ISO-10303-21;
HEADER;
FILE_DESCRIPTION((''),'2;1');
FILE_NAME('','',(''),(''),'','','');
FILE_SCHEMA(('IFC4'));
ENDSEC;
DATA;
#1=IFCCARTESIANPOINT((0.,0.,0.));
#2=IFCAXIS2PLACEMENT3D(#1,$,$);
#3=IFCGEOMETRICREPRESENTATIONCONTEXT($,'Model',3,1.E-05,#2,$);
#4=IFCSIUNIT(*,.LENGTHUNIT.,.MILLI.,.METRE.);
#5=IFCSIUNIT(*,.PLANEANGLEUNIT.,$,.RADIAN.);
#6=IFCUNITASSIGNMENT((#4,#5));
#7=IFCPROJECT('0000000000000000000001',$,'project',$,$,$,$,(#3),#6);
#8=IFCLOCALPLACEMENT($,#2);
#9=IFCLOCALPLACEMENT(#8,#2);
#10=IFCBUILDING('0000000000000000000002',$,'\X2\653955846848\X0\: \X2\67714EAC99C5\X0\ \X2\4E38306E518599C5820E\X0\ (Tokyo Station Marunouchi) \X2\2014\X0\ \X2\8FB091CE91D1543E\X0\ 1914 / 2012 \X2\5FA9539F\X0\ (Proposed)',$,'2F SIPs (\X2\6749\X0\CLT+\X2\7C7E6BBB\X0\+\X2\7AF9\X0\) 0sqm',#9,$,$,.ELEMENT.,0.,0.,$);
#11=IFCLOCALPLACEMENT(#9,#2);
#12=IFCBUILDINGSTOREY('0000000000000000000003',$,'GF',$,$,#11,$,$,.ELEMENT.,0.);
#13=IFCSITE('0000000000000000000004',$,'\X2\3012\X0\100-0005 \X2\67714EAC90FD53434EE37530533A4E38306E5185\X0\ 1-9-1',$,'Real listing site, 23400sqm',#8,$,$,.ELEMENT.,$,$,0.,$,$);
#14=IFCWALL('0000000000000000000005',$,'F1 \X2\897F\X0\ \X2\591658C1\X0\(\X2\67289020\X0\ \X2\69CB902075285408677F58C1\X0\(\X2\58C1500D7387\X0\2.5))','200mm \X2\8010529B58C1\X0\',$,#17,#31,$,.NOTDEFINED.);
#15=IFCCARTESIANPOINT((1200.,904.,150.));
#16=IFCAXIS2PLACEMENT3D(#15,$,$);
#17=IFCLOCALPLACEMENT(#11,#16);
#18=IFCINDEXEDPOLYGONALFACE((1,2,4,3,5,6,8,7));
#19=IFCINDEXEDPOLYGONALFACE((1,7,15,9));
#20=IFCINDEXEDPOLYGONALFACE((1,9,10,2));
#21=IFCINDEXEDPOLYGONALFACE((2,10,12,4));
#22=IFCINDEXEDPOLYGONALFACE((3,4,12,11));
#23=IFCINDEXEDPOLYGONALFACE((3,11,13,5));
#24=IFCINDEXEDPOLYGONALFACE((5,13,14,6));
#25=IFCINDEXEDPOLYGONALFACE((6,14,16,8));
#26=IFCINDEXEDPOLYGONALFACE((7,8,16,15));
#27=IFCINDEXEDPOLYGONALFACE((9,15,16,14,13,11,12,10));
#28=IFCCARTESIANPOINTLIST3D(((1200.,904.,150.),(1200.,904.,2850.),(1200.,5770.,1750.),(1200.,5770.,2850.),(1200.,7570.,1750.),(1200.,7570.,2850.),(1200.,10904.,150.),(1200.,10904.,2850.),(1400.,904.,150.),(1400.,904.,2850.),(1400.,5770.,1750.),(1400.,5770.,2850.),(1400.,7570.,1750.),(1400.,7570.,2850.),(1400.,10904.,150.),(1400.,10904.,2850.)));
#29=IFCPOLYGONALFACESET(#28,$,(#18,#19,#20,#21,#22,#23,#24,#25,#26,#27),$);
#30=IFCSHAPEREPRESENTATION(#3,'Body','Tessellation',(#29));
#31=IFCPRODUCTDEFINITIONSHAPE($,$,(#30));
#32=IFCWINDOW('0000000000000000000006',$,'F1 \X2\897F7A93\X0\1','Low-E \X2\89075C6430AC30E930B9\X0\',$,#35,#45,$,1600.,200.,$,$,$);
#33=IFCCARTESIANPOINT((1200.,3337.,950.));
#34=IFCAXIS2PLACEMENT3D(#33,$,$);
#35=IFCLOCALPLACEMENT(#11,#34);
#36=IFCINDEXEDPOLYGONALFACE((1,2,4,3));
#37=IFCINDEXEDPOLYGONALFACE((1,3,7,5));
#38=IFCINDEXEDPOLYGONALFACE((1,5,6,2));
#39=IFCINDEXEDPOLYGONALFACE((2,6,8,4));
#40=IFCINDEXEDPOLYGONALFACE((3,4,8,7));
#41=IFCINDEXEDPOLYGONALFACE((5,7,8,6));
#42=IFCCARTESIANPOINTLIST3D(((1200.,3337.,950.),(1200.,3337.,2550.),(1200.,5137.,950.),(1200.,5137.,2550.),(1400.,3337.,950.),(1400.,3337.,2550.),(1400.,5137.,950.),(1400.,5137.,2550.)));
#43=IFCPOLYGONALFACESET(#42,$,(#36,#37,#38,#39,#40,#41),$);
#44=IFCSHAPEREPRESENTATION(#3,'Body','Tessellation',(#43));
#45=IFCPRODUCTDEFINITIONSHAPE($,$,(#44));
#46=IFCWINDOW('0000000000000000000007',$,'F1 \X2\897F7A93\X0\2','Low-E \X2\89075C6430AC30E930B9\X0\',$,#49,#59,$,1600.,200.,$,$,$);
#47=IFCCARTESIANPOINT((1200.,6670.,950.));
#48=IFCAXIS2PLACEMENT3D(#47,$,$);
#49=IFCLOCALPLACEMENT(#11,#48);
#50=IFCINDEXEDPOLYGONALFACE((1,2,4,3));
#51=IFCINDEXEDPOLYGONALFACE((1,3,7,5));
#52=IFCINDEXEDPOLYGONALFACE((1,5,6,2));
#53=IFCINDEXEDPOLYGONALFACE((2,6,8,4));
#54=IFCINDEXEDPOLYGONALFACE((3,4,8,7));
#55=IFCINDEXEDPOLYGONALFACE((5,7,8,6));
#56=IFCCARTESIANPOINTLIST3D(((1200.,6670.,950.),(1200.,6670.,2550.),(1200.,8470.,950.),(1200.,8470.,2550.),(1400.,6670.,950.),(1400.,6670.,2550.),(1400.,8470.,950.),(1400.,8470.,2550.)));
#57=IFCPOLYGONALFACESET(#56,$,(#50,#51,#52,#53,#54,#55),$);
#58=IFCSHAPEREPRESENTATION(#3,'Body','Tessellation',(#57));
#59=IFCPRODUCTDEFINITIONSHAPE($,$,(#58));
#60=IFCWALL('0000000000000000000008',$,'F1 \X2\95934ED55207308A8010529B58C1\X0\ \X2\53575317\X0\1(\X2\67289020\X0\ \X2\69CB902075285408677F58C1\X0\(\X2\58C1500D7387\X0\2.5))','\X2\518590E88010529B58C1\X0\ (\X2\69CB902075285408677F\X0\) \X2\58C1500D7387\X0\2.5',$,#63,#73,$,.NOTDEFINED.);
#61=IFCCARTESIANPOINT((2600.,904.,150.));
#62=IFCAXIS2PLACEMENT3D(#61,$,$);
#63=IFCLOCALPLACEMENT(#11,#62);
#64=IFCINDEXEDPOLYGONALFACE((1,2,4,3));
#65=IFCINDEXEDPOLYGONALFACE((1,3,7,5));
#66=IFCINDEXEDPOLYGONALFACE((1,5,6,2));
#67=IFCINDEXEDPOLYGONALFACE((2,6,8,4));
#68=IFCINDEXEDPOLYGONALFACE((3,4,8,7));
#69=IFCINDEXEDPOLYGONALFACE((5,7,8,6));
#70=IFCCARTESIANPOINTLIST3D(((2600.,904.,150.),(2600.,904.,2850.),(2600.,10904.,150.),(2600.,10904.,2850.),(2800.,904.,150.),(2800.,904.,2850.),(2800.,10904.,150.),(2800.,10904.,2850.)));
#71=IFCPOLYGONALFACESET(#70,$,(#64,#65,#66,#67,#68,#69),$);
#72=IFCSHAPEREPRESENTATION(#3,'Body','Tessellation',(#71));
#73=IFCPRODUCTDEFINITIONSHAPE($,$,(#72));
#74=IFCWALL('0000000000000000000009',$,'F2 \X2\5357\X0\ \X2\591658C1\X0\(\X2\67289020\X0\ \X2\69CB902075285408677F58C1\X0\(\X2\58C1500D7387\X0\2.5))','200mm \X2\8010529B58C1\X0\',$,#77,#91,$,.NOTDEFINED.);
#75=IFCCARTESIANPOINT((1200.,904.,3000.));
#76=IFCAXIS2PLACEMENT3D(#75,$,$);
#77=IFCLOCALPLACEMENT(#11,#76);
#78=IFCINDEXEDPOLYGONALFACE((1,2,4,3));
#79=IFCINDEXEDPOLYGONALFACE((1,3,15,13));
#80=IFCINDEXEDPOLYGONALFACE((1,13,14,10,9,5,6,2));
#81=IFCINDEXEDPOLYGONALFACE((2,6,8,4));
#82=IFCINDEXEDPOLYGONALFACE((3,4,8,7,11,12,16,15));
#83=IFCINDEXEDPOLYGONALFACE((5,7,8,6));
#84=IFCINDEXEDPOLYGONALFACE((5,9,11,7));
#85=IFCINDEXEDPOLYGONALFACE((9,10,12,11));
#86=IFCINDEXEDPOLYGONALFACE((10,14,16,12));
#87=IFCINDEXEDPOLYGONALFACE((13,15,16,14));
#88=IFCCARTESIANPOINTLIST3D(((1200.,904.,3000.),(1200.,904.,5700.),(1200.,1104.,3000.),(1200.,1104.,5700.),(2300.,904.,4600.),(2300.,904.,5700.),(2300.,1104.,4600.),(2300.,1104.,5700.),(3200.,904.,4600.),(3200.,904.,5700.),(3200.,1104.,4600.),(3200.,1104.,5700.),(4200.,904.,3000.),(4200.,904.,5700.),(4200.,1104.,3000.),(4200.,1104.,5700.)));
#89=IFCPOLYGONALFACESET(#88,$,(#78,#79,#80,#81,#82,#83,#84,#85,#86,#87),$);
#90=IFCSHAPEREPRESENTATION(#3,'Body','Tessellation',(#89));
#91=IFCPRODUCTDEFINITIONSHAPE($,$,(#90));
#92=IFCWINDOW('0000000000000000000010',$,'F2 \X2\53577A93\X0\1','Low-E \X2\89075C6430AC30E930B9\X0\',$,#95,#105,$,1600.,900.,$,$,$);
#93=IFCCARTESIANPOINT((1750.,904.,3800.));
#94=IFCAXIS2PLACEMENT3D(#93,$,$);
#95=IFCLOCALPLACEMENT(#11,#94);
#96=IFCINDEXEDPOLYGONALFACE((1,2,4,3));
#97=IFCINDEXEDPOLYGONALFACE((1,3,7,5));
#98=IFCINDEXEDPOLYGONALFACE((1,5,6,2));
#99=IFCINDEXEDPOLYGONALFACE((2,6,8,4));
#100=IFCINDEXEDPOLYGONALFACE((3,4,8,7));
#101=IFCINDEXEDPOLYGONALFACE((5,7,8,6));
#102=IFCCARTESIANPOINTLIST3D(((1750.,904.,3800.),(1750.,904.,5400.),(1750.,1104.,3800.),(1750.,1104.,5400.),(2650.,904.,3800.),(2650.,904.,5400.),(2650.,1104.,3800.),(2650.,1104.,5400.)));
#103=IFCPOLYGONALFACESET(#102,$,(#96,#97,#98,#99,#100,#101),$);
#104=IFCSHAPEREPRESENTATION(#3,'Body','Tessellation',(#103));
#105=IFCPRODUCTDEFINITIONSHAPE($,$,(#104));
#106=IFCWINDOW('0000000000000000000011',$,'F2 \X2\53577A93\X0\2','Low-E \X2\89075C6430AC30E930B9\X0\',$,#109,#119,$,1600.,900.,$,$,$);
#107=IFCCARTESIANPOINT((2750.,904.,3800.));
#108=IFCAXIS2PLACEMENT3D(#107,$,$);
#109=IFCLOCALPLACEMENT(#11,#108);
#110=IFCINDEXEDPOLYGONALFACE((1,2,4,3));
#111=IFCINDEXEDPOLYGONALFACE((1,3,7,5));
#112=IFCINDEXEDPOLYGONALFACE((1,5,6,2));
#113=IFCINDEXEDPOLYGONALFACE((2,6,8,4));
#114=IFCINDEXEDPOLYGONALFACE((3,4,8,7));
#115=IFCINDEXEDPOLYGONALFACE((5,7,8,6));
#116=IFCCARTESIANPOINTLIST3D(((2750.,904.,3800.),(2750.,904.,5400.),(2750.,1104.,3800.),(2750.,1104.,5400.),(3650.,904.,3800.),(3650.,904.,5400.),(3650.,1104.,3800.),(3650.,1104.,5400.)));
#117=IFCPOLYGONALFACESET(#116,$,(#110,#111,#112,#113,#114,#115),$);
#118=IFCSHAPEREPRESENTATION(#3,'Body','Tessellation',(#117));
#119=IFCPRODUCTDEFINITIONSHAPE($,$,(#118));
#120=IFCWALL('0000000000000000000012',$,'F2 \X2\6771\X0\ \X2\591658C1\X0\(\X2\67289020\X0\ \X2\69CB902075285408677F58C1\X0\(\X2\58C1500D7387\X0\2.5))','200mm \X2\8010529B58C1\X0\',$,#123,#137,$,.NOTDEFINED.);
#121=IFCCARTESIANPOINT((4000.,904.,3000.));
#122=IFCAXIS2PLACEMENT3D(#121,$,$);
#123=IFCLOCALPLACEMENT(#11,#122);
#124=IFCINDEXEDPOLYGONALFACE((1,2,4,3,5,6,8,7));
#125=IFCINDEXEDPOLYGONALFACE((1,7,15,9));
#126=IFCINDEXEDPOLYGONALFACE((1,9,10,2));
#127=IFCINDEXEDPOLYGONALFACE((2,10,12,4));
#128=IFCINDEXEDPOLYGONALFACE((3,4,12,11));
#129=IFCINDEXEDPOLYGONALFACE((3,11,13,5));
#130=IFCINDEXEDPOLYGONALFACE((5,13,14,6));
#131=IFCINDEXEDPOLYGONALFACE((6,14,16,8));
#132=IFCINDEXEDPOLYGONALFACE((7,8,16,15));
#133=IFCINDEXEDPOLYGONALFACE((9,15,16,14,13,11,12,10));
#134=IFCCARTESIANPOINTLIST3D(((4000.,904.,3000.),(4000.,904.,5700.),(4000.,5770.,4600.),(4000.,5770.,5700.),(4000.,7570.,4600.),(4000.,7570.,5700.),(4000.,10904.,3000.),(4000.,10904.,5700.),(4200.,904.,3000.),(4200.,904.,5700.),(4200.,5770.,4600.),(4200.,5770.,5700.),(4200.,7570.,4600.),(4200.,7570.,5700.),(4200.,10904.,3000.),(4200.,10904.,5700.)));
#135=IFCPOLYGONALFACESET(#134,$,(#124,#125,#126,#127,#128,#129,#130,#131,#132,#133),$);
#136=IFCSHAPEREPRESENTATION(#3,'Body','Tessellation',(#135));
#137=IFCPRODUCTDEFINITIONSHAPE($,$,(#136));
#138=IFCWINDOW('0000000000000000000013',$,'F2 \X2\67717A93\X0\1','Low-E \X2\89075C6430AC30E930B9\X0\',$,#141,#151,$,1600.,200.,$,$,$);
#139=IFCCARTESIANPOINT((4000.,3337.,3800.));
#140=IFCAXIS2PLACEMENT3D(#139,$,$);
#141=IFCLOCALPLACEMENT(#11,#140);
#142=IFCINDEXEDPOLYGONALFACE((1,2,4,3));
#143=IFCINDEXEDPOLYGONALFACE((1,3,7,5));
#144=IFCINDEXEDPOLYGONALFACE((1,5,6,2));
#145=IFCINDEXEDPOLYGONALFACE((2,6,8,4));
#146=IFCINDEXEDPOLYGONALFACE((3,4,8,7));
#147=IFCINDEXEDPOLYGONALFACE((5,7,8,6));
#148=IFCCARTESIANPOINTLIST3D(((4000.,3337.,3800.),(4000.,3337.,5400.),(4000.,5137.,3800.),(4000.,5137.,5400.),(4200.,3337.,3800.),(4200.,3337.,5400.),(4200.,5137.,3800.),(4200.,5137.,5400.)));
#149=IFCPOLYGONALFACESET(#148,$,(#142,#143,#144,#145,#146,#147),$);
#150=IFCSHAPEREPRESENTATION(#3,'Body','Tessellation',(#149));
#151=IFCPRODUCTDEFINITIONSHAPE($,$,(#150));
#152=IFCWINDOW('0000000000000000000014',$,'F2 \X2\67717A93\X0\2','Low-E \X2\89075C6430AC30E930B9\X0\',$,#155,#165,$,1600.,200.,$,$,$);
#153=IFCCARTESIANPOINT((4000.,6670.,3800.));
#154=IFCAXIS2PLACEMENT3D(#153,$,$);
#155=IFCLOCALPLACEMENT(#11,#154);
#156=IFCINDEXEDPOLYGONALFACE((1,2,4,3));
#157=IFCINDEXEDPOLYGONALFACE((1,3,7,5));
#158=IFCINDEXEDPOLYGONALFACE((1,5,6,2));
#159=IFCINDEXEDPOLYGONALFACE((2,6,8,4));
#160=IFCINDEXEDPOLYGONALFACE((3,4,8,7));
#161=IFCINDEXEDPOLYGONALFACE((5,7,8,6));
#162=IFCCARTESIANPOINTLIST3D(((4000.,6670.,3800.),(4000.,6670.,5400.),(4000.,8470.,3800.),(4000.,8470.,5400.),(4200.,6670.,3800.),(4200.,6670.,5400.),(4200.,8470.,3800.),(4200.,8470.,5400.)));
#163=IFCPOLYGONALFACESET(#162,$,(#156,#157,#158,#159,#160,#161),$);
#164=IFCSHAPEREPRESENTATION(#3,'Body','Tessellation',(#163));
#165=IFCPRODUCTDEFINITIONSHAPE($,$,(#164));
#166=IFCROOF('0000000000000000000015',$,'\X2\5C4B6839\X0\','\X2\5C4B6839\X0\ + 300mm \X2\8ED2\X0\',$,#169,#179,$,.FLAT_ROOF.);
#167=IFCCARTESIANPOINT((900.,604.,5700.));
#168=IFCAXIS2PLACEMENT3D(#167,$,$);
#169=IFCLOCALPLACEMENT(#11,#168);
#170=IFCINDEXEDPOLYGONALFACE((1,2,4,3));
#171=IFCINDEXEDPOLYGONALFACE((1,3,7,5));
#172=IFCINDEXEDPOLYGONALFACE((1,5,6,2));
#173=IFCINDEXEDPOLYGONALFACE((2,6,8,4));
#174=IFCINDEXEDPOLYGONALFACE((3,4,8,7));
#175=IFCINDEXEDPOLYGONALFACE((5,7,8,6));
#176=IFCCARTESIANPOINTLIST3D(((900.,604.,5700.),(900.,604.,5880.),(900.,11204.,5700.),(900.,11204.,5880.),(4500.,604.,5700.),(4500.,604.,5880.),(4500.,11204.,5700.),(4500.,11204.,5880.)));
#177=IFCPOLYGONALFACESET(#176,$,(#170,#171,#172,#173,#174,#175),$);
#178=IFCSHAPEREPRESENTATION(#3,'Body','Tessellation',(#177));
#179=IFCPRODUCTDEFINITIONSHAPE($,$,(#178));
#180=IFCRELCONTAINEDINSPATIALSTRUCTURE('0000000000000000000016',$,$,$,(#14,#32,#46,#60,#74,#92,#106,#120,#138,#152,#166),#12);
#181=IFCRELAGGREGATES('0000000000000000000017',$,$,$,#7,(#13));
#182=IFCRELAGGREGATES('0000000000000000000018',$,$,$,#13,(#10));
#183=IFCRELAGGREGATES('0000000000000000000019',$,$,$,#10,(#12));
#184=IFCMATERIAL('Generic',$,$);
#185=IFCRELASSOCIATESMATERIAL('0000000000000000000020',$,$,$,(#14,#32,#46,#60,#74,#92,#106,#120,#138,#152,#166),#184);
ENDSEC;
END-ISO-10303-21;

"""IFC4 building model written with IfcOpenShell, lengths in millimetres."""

from ifc_helpers import new_model, si_unit, frame, frame_2d, origin, place, context, project, spatial, rectangle, extrude, material, element, fill, save


model = new_model("IFC4")

# Units and contexts
model_context = context("Model", 3, precision=1e-05, world=origin())
ifc_project = project(units=[si_unit("LENGTHUNIT", "METRE", prefix="MILLI"), si_unit("PLANEANGLEUNIT", "RADIAN")], contexts=[model_context])

# Site, building, storey
site_placement = place(None, origin())
site = spatial("IfcSite", under=ifc_project, at=site_placement, Name="〒100-0005 東京都千代田区丸の内 1-9-1", ObjectType="Real listing site, 23400sqm", CompositionType="ELEMENT", RefElevation=0.0)
building_placement = place(site_placement, origin())
building = spatial("IfcBuilding", under=site, at=building_placement, Name="改善案: 東京駅 丸の内駅舎 (Tokyo Station Marunouchi) — 辰野金吾 1914 / 2012 復原 (Proposed)", ObjectType="2F SIPs (杉CLT+籾殻+竹) 0sqm", CompositionType="ELEMENT", ElevationOfRefHeight=0.0, ElevationOfTerrain=0.0)
storey_placement = place(building_placement, origin())
storey = spatial("IfcBuildingStorey", under=building, at=storey_placement, Name="GF", CompositionType="ELEMENT", Elevation=0.0)

# Shared definitions
ifc_material_1 = material(Name="Generic")

# Wall, openings, windows
wall_1_placement = place(storey_placement, frame((1200.0, 904.0, 150.0)))
wall_1 = element("IfcWall", 1, at=wall_1_placement, inside=storey, material=ifc_material_1, Name="F1 西 外壁(木造 構造用合板壁(壁倍率2.5))", Description="200mm 耐力壁", PredefinedType="NOTDEFINED", context=model_context, shape_type="SweptSolid", body=[
    extrude(rectangle(XDim=200.0, YDim=10000.0, at=frame_2d((100.0, 5000.0))), frame((1200.0, 904.0, 150.0)), (0.0, 0.0, 1.0), 2700.0),
])
opening_1_placement = place(storey_placement, frame((1200.0, 3337.0, 950.0)))
opening_1 = element("IfcOpeningElement", 2, at=opening_1_placement, cuts=wall_1, PredefinedType="NOTDEFINED", context=model_context, shape_type="SweptSolid", body=[
    extrude(rectangle(XDim=200.0, YDim=1800.0, at=frame_2d((100.0, 900.0))), frame((1200.0, 3337.0, 950.0)), (0.0, 0.0, 1.0), 1600.0),
])
opening_2_placement = place(storey_placement, frame((1200.0, 6670.0, 950.0)))
opening_2 = element("IfcOpeningElement", 3, at=opening_2_placement, cuts=wall_1, PredefinedType="NOTDEFINED", context=model_context, shape_type="SweptSolid", body=[
    extrude(rectangle(XDim=200.0, YDim=1800.0, at=frame_2d((100.0, 900.0))), frame((1200.0, 6670.0, 950.0)), (0.0, 0.0, 1.0), 1600.0),
])
window_1_placement = place(storey_placement, frame((1200.0, 3337.0, 950.0)))
window_1 = element("IfcWindow", 4, at=window_1_placement, inside=storey, material=ifc_material_1, Name="F1 西窓1", Description="Low-E 複層ガラス", OverallHeight=1600.0, OverallWidth=200.0, context=model_context, shape_type="SweptSolid", body=[
    extrude(rectangle(XDim=200.0, YDim=1800.0, at=frame_2d((100.0, 900.0))), frame((1200.0, 3337.0, 950.0)), (0.0, 0.0, 1.0), 1600.0),
])
fill(opening_1, window_1)
window_2_placement = place(storey_placement, frame((1200.0, 6670.0, 950.0)))
window_2 = element("IfcWindow", 5, at=window_2_placement, inside=storey, material=ifc_material_1, Name="F1 西窓2", Description="Low-E 複層ガラス", OverallHeight=1600.0, OverallWidth=200.0, context=model_context, shape_type="SweptSolid", body=[
    extrude(rectangle(XDim=200.0, YDim=1800.0, at=frame_2d((100.0, 900.0))), frame((1200.0, 6670.0, 950.0)), (0.0, 0.0, 1.0), 1600.0),
])
fill(opening_2, window_2)

# Wall
wall_2_placement = place(storey_placement, frame((2600.0, 904.0, 150.0)))
element("IfcWall", 6, at=wall_2_placement, inside=storey, material=ifc_material_1, Name="F1 間仕切り耐力壁 南北1(木造 構造用合板壁(壁倍率2.5))", Description="内部耐力壁 (構造用合板) 壁倍率2.5", PredefinedType="NOTDEFINED", context=model_context, shape_type="SweptSolid", body=[
    extrude(rectangle(XDim=200.0, YDim=10000.0, at=frame_2d((100.0, 5000.0))), frame((2600.0, 904.0, 150.0)), (0.0, 0.0, 1.0), 2700.0),
])

# Walls, openings, windows
wall_3_placement = place(storey_placement, frame((1200.0, 904.0, 3000.0)))
wall_3 = element("IfcWall", 7, at=wall_3_placement, inside=storey, material=ifc_material_1, Name="F2 南 外壁(木造 構造用合板壁(壁倍率2.5))", Description="200mm 耐力壁", PredefinedType="NOTDEFINED", context=model_context, shape_type="SweptSolid", body=[
    extrude(rectangle(XDim=3000.0, YDim=200.0, at=frame_2d((1500.0, 100.0))), frame((1200.0, 904.0, 3000.0)), (0.0, 0.0, 1.0), 2700.0),
])
opening_3_placement = place(storey_placement, frame((1750.0, 904.0, 3800.0)))
opening_3 = element("IfcOpeningElement", 8, at=opening_3_placement, cuts=wall_3, PredefinedType="NOTDEFINED", context=model_context, shape_type="SweptSolid", body=[
    extrude(rectangle(XDim=900.0, YDim=200.0, at=frame_2d((450.0, 100.0))), frame((1750.0, 904.0, 3800.0)), (0.0, 0.0, 1.0), 1600.0),
])
opening_4_placement = place(storey_placement, frame((2750.0, 904.0, 3800.0)))
opening_4 = element("IfcOpeningElement", 9, at=opening_4_placement, cuts=wall_3, PredefinedType="NOTDEFINED", context=model_context, shape_type="SweptSolid", body=[
    extrude(rectangle(XDim=900.0, YDim=200.0, at=frame_2d((450.0, 100.0))), frame((2750.0, 904.0, 3800.0)), (0.0, 0.0, 1.0), 1600.0),
])
window_3_placement = place(storey_placement, frame((1750.0, 904.0, 3800.0)))
window_3 = element("IfcWindow", 10, at=window_3_placement, inside=storey, material=ifc_material_1, Name="F2 南窓1", Description="Low-E 複層ガラス", OverallHeight=1600.0, OverallWidth=900.0, context=model_context, shape_type="SweptSolid", body=[
    extrude(rectangle(XDim=900.0, YDim=200.0, at=frame_2d((450.0, 100.0))), frame((1750.0, 904.0, 3800.0)), (0.0, 0.0, 1.0), 1600.0),
])
fill(opening_3, window_3)
window_4_placement = place(storey_placement, frame((2750.0, 904.0, 3800.0)))
window_4 = element("IfcWindow", 11, at=window_4_placement, inside=storey, material=ifc_material_1, Name="F2 南窓2", Description="Low-E 複層ガラス", OverallHeight=1600.0, OverallWidth=900.0, context=model_context, shape_type="SweptSolid", body=[
    extrude(rectangle(XDim=900.0, YDim=200.0, at=frame_2d((450.0, 100.0))), frame((2750.0, 904.0, 3800.0)), (0.0, 0.0, 1.0), 1600.0),
])
fill(opening_4, window_4)
wall_4_placement = place(storey_placement, frame((4000.0, 904.0, 3000.0)))
wall_4 = element("IfcWall", 12, at=wall_4_placement, inside=storey, material=ifc_material_1, Name="F2 東 外壁(木造 構造用合板壁(壁倍率2.5))", Description="200mm 耐力壁", PredefinedType="NOTDEFINED", context=model_context, shape_type="SweptSolid", body=[
    extrude(rectangle(XDim=200.0, YDim=10000.0, at=frame_2d((100.0, 5000.0))), frame((4000.0, 904.0, 3000.0)), (0.0, 0.0, 1.0), 2700.0),
])
opening_5_placement = place(storey_placement, frame((4000.0, 3337.0, 3800.0)))
opening_5 = element("IfcOpeningElement", 13, at=opening_5_placement, cuts=wall_4, PredefinedType="NOTDEFINED", context=model_context, shape_type="SweptSolid", body=[
    extrude(rectangle(XDim=200.0, YDim=1800.0, at=frame_2d((100.0, 900.0))), frame((4000.0, 3337.0, 3800.0)), (0.0, 0.0, 1.0), 1600.0),
])
opening_6_placement = place(storey_placement, frame((4000.0, 6670.0, 3800.0)))
opening_6 = element("IfcOpeningElement", 14, at=opening_6_placement, cuts=wall_4, PredefinedType="NOTDEFINED", context=model_context, shape_type="SweptSolid", body=[
    extrude(rectangle(XDim=200.0, YDim=1800.0, at=frame_2d((100.0, 900.0))), frame((4000.0, 6670.0, 3800.0)), (0.0, 0.0, 1.0), 1600.0),
])
window_5_placement = place(storey_placement, frame((4000.0, 3337.0, 3800.0)))
window_5 = element("IfcWindow", 15, at=window_5_placement, inside=storey, material=ifc_material_1, Name="F2 東窓1", Description="Low-E 複層ガラス", OverallHeight=1600.0, OverallWidth=200.0, context=model_context, shape_type="SweptSolid", body=[
    extrude(rectangle(XDim=200.0, YDim=1800.0, at=frame_2d((100.0, 900.0))), frame((4000.0, 3337.0, 3800.0)), (0.0, 0.0, 1.0), 1600.0),
])
fill(opening_5, window_5)
window_6_placement = place(storey_placement, frame((4000.0, 6670.0, 3800.0)))
window_6 = element("IfcWindow", 16, at=window_6_placement, inside=storey, material=ifc_material_1, Name="F2 東窓2", Description="Low-E 複層ガラス", OverallHeight=1600.0, OverallWidth=200.0, context=model_context, shape_type="SweptSolid", body=[
    extrude(rectangle(XDim=200.0, YDim=1800.0, at=frame_2d((100.0, 900.0))), frame((4000.0, 6670.0, 3800.0)), (0.0, 0.0, 1.0), 1600.0),
])
fill(opening_6, window_6)

# Roof
roof_placement = place(storey_placement, frame((900.0, 604.0, 5700.0)))
element("IfcRoof", 17, at=roof_placement, inside=storey, material=ifc_material_1, Name="屋根", Description="屋根 + 300mm 軒", PredefinedType="FLAT_ROOF", context=model_context, shape_type="SweptSolid", body=[
    extrude(rectangle(XDim=3600.0, YDim=10600.0, at=frame_2d((1800.0, 5300.0))), frame((900.0, 604.0, 5700.0)), (0.0, 0.0, 1.0), 180.0),
])

save(model, "model.ifc")
